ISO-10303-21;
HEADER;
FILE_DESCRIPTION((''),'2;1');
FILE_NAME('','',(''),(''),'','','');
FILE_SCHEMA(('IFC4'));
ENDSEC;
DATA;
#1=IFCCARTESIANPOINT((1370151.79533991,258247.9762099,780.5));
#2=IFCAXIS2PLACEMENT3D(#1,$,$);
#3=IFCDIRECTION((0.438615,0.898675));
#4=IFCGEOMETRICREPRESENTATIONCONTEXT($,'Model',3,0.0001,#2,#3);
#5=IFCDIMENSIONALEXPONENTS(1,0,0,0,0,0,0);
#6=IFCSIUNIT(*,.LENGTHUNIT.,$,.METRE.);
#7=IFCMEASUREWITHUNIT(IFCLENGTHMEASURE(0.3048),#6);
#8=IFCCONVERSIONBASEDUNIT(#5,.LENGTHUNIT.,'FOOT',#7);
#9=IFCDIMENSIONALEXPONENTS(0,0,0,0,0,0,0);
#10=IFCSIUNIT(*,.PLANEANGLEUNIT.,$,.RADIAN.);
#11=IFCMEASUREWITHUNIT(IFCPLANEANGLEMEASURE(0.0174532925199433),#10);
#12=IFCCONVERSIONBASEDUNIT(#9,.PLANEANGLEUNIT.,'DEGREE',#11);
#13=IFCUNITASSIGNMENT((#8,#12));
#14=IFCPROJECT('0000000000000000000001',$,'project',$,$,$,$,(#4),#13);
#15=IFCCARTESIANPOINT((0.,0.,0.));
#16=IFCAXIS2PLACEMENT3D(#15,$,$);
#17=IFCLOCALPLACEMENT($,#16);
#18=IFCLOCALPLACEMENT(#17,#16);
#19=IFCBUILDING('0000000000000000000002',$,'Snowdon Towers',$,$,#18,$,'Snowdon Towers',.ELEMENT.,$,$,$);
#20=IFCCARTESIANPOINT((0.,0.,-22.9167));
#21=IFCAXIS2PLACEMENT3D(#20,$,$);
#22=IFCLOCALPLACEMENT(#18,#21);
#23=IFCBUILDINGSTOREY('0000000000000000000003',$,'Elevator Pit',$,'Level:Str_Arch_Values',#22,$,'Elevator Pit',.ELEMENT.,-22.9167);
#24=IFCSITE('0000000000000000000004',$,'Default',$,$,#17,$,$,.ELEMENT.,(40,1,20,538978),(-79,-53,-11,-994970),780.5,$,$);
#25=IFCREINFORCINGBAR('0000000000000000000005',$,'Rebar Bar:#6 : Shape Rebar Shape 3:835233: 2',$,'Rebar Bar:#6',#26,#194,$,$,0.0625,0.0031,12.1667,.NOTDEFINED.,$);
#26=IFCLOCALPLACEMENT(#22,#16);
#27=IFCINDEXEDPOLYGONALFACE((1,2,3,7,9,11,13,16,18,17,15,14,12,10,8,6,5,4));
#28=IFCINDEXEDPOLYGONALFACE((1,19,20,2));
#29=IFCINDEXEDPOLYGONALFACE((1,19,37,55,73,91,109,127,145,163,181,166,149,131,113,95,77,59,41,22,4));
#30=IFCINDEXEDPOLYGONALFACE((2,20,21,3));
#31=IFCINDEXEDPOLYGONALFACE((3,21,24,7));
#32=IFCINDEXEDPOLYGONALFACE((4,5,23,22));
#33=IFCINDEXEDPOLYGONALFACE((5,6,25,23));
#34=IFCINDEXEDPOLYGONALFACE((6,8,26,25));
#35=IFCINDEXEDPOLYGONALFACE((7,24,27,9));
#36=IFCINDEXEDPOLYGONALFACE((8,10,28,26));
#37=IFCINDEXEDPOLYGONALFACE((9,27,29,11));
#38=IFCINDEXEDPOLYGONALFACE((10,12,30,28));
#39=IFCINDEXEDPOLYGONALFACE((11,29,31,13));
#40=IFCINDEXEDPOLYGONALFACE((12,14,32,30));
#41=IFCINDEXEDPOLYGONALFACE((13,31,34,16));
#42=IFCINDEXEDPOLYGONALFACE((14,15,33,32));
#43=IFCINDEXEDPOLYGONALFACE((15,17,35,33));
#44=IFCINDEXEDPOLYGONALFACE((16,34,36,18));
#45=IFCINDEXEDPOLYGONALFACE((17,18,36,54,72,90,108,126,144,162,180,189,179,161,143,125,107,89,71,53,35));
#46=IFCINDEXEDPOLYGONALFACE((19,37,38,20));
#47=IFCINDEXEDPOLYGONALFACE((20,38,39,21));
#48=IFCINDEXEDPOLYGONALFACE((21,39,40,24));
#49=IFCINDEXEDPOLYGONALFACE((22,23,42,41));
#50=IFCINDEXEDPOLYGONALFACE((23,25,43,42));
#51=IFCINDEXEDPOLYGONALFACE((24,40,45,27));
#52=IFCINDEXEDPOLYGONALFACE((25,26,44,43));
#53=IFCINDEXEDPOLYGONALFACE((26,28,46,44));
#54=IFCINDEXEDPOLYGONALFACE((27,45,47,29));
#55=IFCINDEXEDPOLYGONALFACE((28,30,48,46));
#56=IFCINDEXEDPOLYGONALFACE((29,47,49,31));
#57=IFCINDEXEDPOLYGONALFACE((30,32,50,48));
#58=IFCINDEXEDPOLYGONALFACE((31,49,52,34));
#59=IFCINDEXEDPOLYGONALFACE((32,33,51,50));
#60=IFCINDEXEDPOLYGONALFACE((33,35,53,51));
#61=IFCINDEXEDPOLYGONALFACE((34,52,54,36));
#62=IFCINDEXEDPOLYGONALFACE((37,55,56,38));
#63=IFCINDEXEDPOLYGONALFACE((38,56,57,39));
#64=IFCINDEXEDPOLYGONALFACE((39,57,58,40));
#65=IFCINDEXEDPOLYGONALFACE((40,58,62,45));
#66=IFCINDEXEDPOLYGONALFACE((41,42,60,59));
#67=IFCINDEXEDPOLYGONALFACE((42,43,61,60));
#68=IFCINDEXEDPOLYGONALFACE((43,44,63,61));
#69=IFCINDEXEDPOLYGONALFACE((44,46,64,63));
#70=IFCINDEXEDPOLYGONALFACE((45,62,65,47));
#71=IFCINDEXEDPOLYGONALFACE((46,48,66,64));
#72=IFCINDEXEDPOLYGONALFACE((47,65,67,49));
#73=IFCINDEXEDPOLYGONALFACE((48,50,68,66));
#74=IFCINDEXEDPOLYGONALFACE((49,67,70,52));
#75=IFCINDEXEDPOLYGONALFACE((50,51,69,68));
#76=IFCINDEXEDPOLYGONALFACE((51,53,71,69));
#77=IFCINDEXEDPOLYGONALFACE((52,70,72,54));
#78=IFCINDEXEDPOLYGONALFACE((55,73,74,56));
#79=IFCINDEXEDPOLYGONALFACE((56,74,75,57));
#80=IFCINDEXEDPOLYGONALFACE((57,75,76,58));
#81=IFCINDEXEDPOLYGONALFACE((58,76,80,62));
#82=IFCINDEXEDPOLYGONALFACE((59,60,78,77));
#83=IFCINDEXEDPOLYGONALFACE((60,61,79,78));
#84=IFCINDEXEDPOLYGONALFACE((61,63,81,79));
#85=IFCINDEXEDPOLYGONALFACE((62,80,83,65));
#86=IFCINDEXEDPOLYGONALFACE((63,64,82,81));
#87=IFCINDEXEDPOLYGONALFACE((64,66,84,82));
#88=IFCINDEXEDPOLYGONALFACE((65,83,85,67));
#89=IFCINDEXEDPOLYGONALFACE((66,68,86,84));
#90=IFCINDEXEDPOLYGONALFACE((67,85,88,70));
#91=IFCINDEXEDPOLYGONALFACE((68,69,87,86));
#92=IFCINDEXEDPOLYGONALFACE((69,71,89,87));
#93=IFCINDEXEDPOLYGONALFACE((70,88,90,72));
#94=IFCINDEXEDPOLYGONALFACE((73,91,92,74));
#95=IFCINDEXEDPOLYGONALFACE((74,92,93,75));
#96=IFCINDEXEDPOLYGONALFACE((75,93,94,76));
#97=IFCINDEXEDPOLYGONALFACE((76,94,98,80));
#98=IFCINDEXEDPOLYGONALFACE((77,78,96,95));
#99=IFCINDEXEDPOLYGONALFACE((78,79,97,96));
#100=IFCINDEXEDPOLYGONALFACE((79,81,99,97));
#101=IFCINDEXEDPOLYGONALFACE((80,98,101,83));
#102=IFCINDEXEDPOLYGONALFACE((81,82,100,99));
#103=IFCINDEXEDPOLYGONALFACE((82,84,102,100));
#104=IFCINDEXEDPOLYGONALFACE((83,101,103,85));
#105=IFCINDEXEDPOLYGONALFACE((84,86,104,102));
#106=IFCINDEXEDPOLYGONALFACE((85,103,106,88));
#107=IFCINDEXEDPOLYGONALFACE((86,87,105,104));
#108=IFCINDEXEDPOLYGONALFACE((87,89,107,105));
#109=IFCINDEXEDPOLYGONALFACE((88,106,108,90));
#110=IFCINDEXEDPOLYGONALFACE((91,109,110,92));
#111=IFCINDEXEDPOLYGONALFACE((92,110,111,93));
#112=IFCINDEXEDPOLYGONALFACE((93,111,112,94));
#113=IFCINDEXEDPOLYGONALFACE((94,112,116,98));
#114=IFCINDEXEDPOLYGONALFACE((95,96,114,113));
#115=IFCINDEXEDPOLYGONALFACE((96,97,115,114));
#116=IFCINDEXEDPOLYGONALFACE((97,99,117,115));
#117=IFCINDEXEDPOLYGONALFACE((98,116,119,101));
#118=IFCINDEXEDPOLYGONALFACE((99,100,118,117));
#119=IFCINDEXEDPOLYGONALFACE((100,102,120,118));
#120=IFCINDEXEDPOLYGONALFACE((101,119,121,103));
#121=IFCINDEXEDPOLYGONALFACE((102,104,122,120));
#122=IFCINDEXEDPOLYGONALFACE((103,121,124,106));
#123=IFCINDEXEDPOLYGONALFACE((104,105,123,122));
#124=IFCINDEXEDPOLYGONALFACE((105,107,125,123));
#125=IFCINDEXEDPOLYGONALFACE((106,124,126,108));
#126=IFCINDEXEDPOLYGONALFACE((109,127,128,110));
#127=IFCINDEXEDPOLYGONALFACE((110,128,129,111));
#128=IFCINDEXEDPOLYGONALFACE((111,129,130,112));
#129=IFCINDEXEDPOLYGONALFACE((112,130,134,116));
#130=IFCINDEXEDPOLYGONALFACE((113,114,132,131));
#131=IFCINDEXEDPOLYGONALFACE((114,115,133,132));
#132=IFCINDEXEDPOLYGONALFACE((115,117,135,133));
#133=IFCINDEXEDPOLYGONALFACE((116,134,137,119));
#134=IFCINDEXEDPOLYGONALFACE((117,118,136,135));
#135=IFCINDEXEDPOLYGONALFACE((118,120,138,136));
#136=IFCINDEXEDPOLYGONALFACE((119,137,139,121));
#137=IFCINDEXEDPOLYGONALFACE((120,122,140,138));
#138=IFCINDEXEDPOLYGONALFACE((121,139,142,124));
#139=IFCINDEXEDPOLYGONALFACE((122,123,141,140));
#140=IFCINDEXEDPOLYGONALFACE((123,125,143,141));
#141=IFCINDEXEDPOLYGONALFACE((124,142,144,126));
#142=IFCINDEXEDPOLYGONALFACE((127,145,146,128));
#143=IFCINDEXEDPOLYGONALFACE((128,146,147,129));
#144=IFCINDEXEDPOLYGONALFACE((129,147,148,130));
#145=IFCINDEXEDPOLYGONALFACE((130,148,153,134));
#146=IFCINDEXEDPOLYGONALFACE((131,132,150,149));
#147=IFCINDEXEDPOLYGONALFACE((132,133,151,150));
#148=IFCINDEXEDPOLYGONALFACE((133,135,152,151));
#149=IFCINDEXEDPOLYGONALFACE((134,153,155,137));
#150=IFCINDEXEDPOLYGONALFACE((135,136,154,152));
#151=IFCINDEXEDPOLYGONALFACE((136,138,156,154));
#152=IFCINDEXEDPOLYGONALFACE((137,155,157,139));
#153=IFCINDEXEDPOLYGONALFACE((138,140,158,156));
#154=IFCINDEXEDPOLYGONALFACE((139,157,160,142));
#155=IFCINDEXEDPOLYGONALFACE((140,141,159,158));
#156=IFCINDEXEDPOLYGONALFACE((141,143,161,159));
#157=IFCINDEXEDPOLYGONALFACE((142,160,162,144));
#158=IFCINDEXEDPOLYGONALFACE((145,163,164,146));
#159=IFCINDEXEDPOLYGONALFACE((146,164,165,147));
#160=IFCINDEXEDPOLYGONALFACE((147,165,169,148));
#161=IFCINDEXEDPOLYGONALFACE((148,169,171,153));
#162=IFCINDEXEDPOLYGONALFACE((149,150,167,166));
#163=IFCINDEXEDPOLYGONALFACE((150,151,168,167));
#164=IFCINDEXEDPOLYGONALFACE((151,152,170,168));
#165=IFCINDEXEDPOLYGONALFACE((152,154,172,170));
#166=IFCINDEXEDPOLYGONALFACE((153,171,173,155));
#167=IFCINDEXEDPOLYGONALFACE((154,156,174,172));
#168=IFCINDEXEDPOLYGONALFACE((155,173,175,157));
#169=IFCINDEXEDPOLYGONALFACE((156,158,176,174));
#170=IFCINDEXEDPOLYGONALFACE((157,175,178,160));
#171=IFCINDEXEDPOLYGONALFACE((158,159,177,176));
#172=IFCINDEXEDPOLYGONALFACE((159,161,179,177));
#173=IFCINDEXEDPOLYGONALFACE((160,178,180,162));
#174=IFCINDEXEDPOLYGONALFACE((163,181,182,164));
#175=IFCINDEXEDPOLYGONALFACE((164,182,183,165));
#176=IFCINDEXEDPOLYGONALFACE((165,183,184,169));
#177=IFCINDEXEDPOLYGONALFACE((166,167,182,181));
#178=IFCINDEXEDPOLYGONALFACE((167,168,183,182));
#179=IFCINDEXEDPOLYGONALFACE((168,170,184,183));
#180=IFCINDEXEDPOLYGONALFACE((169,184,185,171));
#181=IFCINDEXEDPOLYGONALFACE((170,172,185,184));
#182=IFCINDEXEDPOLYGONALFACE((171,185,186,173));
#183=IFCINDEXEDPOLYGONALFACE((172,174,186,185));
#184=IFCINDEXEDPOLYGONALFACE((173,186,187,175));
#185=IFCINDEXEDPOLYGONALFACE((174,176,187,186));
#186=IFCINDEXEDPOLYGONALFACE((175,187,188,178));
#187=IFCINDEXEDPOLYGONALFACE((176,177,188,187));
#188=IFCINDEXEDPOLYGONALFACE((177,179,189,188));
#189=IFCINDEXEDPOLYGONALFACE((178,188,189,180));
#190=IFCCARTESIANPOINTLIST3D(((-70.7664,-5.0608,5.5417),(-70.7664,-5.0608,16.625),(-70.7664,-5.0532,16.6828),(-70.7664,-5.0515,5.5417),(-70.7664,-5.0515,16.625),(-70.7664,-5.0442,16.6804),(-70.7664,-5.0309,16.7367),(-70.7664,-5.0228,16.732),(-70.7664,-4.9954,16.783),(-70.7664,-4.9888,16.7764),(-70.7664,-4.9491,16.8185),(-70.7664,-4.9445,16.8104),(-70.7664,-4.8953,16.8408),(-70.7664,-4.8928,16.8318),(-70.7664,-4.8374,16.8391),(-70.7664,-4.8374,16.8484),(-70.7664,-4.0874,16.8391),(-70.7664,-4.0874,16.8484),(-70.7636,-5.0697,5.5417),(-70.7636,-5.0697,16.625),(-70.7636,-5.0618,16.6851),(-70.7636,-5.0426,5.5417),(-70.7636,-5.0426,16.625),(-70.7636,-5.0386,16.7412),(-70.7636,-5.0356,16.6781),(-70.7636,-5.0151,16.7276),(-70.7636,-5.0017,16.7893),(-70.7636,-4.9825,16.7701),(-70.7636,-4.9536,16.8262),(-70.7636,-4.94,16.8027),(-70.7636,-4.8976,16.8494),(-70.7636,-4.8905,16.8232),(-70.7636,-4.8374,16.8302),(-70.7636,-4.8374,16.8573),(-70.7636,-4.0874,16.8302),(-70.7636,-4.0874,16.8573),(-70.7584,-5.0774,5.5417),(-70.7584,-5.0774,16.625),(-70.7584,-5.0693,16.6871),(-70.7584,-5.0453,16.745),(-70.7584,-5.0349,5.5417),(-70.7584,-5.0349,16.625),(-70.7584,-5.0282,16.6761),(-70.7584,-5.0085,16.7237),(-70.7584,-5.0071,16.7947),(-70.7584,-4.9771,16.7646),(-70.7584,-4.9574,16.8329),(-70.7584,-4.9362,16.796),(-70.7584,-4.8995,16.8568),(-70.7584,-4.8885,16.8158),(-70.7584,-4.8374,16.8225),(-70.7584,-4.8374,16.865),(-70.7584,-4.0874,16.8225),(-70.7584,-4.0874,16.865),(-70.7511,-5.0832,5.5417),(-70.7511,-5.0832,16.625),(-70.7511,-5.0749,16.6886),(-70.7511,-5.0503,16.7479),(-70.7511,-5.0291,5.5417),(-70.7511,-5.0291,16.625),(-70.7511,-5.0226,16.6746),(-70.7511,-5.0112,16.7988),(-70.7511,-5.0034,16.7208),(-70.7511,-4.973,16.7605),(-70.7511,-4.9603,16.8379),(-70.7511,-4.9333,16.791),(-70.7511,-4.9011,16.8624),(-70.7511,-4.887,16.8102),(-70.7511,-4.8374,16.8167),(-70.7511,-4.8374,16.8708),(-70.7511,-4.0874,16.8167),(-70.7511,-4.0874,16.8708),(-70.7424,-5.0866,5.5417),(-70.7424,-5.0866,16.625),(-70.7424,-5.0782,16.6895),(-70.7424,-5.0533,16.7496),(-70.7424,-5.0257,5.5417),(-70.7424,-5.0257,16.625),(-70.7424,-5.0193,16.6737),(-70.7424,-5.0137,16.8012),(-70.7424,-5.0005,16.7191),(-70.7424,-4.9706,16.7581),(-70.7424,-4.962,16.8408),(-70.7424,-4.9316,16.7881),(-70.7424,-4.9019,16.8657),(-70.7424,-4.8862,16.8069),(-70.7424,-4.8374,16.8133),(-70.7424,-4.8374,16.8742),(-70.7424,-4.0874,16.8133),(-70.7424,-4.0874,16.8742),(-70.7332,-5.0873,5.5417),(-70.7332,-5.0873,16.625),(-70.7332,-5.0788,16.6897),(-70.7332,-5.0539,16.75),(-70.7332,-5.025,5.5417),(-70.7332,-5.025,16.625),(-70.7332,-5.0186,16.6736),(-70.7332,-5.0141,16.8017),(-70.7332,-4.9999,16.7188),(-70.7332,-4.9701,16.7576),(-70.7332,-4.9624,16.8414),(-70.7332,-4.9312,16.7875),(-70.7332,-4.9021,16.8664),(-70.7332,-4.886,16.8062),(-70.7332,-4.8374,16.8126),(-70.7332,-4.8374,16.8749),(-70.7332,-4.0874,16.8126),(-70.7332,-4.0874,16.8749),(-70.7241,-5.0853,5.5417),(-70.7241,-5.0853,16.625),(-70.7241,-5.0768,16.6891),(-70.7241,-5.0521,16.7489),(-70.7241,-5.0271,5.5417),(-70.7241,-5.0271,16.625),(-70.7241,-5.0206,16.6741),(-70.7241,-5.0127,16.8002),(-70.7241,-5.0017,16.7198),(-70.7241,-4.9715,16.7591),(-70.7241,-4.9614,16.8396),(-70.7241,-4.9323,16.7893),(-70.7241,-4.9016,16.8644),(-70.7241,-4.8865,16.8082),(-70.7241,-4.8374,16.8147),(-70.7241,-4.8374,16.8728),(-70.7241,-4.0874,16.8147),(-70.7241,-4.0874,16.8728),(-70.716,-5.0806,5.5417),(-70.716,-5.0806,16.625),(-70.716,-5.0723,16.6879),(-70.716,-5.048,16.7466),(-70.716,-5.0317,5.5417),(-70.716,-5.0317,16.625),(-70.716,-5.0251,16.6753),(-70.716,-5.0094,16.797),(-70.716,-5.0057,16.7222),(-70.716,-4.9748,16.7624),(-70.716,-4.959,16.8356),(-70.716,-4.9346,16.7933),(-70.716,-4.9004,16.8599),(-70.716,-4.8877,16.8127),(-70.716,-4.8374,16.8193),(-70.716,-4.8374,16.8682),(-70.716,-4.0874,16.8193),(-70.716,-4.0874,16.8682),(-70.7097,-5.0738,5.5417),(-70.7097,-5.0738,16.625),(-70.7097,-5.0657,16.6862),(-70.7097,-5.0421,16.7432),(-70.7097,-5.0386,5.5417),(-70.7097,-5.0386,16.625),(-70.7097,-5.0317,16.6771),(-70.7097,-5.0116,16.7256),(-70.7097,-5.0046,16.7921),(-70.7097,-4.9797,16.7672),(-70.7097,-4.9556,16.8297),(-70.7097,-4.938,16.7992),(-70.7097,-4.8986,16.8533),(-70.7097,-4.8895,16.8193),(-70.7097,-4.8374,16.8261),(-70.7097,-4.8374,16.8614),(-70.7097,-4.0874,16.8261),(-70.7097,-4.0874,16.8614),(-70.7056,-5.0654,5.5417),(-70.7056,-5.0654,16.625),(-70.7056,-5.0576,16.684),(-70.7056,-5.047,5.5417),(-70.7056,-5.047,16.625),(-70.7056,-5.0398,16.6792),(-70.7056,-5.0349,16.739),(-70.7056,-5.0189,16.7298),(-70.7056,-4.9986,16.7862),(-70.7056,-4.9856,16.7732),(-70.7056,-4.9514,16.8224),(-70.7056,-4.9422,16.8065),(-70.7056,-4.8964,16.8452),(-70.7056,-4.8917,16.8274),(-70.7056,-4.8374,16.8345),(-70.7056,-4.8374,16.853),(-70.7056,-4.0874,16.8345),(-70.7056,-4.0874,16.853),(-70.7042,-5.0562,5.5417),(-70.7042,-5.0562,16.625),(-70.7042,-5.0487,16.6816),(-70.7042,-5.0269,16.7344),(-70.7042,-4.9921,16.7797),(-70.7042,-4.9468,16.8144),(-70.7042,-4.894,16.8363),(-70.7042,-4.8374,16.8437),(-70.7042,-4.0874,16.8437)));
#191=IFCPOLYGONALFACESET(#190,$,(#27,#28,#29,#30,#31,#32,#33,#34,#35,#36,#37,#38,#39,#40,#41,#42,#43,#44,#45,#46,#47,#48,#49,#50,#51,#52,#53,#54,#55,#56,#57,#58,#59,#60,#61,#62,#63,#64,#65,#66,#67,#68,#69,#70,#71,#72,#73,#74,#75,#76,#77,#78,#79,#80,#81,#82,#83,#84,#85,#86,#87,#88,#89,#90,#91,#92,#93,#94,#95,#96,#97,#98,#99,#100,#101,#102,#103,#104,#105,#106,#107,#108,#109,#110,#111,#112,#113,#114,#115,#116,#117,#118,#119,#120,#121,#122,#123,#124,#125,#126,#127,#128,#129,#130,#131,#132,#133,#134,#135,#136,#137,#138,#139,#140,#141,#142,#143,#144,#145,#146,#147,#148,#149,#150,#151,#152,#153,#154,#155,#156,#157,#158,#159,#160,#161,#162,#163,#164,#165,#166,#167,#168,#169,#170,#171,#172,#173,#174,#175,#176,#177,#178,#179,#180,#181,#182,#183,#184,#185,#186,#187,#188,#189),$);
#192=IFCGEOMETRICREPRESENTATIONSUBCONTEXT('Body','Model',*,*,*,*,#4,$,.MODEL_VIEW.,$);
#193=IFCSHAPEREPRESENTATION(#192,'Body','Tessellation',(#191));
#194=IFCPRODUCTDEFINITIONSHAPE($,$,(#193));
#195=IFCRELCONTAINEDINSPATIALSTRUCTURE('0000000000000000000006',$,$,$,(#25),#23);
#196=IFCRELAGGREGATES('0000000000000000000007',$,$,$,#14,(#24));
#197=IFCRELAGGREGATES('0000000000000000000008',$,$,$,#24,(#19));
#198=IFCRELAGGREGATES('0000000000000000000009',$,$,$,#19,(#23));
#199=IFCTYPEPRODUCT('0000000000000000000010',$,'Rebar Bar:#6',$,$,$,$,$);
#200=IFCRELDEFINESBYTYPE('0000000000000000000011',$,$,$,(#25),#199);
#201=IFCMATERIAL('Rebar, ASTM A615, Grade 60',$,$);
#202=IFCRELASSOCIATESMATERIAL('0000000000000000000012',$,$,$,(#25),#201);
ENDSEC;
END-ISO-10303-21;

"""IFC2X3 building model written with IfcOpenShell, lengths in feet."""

from ifc_helpers import new_model, entity, si_unit, converted_unit, direction, frame, origin, place, context, subcontext, project, spatial, material, type_object, element, save


model = new_model("IFC2X3")

# Units and contexts
model_context = context("Model", 3, precision=0.0001, world=frame((1370151.79533991, 258247.9762099, 780.5)), true_north=direction((0.438615, 0.898675)))
body_context = subcontext(model_context, "Body", "Model", "MODEL_VIEW")
ifc_project = project(units=[converted_unit("LENGTHUNIT", "FOOT", entity("IfcLengthMeasure", 0.3048), si_unit("LENGTHUNIT", "METRE"), dimensions=[1, 0, 0, 0, 0, 0, 0]), converted_unit("PLANEANGLEUNIT", "DEGREE", entity("IfcPlaneAngleMeasure", 0.0174532925199433), si_unit("PLANEANGLEUNIT", "RADIAN"), dimensions=[0, 0, 0, 0, 0, 0, 0])], contexts=[model_context])

# Site, building, storey
site_placement = place(None, origin())
site = spatial("IfcSite", under=ifc_project, at=site_placement, Name="Default", CompositionType="ELEMENT", RefLatitude=(40, 1, 20, 538978), RefLongitude=(-79, -53, -11, -994970), RefElevation=780.5)
building_placement = place(site_placement, origin())
building = spatial("IfcBuilding", under=site, at=building_placement, Name="Snowdon Towers", LongName="Snowdon Towers", CompositionType="ELEMENT")
storey_placement = place(building_placement, frame((0.0, 0.0, -22.9167)))
storey = spatial("IfcBuildingStorey", under=building, at=storey_placement, Name="Elevator Pit", ObjectType="Level:Str_Arch_Values", LongName="Elevator Pit", CompositionType="ELEMENT", Elevation=-22.9167)

# Reinforcing bar
ifc_material_1 = material(Name="Rebar, ASTM A615, Grade 60")
type_product = type_object("IfcTypeProduct", Name="Rebar Bar:#6")
reinforcing_bar_1_placement = place(storey_placement, origin())
element("IfcReinforcingBar", 1, at=reinforcing_bar_1_placement, inside=storey, type_object=type_product, material=ifc_material_1, Name="Rebar Bar:#6 : Shape Rebar Shape 3:835233: 2", ObjectType="Rebar Bar:#6", BarLength=12.1667, BarRole="NOTDEFINED", CrossSectionArea=0.0031, NominalDiameter=0.0625, context=body_context, shape_type="AdvancedSweptSolid", body=[
    entity("IfcSweptDiskSolid", entity("IfcCompositeCurve", [entity("IfcCompositeCurveSegment", "CONTINUOUS", True, entity("IfcPolyline", [entity("IfcCartesianPoint", [-70.7355, -5.0562, 5.5417]), entity("IfcCartesianPoint", [-70.7355, -5.0562, 16.625])])), entity("IfcCompositeCurveSegment", "CONTINUOUS", True, entity("IfcTrimmedCurve", entity("IfcCircle", entity("IfcAxis2Placement3D", entity("IfcCartesianPoint", [-70.7355, -4.8374, 16.625]), entity("IfcDirection", [-1.0, 0.0, 0.0]), entity("IfcDirection", [0.0, 0.0, 1.0])), 0.2188), [entity("IfcParameterValue", 270.0)], [entity("IfcParameterValue", 360.0)], True, "PARAMETER")), entity("IfcCompositeCurveSegment", "CONTINUOUS", True, entity("IfcPolyline", [entity("IfcCartesianPoint", [-70.7355, -4.8374, 16.8437]), entity("IfcCartesianPoint", [-70.7355, -4.0874, 16.8437])]))], False), 0.0312, None, 0.0, 92.0),
])

save(model, "model.ifc")
